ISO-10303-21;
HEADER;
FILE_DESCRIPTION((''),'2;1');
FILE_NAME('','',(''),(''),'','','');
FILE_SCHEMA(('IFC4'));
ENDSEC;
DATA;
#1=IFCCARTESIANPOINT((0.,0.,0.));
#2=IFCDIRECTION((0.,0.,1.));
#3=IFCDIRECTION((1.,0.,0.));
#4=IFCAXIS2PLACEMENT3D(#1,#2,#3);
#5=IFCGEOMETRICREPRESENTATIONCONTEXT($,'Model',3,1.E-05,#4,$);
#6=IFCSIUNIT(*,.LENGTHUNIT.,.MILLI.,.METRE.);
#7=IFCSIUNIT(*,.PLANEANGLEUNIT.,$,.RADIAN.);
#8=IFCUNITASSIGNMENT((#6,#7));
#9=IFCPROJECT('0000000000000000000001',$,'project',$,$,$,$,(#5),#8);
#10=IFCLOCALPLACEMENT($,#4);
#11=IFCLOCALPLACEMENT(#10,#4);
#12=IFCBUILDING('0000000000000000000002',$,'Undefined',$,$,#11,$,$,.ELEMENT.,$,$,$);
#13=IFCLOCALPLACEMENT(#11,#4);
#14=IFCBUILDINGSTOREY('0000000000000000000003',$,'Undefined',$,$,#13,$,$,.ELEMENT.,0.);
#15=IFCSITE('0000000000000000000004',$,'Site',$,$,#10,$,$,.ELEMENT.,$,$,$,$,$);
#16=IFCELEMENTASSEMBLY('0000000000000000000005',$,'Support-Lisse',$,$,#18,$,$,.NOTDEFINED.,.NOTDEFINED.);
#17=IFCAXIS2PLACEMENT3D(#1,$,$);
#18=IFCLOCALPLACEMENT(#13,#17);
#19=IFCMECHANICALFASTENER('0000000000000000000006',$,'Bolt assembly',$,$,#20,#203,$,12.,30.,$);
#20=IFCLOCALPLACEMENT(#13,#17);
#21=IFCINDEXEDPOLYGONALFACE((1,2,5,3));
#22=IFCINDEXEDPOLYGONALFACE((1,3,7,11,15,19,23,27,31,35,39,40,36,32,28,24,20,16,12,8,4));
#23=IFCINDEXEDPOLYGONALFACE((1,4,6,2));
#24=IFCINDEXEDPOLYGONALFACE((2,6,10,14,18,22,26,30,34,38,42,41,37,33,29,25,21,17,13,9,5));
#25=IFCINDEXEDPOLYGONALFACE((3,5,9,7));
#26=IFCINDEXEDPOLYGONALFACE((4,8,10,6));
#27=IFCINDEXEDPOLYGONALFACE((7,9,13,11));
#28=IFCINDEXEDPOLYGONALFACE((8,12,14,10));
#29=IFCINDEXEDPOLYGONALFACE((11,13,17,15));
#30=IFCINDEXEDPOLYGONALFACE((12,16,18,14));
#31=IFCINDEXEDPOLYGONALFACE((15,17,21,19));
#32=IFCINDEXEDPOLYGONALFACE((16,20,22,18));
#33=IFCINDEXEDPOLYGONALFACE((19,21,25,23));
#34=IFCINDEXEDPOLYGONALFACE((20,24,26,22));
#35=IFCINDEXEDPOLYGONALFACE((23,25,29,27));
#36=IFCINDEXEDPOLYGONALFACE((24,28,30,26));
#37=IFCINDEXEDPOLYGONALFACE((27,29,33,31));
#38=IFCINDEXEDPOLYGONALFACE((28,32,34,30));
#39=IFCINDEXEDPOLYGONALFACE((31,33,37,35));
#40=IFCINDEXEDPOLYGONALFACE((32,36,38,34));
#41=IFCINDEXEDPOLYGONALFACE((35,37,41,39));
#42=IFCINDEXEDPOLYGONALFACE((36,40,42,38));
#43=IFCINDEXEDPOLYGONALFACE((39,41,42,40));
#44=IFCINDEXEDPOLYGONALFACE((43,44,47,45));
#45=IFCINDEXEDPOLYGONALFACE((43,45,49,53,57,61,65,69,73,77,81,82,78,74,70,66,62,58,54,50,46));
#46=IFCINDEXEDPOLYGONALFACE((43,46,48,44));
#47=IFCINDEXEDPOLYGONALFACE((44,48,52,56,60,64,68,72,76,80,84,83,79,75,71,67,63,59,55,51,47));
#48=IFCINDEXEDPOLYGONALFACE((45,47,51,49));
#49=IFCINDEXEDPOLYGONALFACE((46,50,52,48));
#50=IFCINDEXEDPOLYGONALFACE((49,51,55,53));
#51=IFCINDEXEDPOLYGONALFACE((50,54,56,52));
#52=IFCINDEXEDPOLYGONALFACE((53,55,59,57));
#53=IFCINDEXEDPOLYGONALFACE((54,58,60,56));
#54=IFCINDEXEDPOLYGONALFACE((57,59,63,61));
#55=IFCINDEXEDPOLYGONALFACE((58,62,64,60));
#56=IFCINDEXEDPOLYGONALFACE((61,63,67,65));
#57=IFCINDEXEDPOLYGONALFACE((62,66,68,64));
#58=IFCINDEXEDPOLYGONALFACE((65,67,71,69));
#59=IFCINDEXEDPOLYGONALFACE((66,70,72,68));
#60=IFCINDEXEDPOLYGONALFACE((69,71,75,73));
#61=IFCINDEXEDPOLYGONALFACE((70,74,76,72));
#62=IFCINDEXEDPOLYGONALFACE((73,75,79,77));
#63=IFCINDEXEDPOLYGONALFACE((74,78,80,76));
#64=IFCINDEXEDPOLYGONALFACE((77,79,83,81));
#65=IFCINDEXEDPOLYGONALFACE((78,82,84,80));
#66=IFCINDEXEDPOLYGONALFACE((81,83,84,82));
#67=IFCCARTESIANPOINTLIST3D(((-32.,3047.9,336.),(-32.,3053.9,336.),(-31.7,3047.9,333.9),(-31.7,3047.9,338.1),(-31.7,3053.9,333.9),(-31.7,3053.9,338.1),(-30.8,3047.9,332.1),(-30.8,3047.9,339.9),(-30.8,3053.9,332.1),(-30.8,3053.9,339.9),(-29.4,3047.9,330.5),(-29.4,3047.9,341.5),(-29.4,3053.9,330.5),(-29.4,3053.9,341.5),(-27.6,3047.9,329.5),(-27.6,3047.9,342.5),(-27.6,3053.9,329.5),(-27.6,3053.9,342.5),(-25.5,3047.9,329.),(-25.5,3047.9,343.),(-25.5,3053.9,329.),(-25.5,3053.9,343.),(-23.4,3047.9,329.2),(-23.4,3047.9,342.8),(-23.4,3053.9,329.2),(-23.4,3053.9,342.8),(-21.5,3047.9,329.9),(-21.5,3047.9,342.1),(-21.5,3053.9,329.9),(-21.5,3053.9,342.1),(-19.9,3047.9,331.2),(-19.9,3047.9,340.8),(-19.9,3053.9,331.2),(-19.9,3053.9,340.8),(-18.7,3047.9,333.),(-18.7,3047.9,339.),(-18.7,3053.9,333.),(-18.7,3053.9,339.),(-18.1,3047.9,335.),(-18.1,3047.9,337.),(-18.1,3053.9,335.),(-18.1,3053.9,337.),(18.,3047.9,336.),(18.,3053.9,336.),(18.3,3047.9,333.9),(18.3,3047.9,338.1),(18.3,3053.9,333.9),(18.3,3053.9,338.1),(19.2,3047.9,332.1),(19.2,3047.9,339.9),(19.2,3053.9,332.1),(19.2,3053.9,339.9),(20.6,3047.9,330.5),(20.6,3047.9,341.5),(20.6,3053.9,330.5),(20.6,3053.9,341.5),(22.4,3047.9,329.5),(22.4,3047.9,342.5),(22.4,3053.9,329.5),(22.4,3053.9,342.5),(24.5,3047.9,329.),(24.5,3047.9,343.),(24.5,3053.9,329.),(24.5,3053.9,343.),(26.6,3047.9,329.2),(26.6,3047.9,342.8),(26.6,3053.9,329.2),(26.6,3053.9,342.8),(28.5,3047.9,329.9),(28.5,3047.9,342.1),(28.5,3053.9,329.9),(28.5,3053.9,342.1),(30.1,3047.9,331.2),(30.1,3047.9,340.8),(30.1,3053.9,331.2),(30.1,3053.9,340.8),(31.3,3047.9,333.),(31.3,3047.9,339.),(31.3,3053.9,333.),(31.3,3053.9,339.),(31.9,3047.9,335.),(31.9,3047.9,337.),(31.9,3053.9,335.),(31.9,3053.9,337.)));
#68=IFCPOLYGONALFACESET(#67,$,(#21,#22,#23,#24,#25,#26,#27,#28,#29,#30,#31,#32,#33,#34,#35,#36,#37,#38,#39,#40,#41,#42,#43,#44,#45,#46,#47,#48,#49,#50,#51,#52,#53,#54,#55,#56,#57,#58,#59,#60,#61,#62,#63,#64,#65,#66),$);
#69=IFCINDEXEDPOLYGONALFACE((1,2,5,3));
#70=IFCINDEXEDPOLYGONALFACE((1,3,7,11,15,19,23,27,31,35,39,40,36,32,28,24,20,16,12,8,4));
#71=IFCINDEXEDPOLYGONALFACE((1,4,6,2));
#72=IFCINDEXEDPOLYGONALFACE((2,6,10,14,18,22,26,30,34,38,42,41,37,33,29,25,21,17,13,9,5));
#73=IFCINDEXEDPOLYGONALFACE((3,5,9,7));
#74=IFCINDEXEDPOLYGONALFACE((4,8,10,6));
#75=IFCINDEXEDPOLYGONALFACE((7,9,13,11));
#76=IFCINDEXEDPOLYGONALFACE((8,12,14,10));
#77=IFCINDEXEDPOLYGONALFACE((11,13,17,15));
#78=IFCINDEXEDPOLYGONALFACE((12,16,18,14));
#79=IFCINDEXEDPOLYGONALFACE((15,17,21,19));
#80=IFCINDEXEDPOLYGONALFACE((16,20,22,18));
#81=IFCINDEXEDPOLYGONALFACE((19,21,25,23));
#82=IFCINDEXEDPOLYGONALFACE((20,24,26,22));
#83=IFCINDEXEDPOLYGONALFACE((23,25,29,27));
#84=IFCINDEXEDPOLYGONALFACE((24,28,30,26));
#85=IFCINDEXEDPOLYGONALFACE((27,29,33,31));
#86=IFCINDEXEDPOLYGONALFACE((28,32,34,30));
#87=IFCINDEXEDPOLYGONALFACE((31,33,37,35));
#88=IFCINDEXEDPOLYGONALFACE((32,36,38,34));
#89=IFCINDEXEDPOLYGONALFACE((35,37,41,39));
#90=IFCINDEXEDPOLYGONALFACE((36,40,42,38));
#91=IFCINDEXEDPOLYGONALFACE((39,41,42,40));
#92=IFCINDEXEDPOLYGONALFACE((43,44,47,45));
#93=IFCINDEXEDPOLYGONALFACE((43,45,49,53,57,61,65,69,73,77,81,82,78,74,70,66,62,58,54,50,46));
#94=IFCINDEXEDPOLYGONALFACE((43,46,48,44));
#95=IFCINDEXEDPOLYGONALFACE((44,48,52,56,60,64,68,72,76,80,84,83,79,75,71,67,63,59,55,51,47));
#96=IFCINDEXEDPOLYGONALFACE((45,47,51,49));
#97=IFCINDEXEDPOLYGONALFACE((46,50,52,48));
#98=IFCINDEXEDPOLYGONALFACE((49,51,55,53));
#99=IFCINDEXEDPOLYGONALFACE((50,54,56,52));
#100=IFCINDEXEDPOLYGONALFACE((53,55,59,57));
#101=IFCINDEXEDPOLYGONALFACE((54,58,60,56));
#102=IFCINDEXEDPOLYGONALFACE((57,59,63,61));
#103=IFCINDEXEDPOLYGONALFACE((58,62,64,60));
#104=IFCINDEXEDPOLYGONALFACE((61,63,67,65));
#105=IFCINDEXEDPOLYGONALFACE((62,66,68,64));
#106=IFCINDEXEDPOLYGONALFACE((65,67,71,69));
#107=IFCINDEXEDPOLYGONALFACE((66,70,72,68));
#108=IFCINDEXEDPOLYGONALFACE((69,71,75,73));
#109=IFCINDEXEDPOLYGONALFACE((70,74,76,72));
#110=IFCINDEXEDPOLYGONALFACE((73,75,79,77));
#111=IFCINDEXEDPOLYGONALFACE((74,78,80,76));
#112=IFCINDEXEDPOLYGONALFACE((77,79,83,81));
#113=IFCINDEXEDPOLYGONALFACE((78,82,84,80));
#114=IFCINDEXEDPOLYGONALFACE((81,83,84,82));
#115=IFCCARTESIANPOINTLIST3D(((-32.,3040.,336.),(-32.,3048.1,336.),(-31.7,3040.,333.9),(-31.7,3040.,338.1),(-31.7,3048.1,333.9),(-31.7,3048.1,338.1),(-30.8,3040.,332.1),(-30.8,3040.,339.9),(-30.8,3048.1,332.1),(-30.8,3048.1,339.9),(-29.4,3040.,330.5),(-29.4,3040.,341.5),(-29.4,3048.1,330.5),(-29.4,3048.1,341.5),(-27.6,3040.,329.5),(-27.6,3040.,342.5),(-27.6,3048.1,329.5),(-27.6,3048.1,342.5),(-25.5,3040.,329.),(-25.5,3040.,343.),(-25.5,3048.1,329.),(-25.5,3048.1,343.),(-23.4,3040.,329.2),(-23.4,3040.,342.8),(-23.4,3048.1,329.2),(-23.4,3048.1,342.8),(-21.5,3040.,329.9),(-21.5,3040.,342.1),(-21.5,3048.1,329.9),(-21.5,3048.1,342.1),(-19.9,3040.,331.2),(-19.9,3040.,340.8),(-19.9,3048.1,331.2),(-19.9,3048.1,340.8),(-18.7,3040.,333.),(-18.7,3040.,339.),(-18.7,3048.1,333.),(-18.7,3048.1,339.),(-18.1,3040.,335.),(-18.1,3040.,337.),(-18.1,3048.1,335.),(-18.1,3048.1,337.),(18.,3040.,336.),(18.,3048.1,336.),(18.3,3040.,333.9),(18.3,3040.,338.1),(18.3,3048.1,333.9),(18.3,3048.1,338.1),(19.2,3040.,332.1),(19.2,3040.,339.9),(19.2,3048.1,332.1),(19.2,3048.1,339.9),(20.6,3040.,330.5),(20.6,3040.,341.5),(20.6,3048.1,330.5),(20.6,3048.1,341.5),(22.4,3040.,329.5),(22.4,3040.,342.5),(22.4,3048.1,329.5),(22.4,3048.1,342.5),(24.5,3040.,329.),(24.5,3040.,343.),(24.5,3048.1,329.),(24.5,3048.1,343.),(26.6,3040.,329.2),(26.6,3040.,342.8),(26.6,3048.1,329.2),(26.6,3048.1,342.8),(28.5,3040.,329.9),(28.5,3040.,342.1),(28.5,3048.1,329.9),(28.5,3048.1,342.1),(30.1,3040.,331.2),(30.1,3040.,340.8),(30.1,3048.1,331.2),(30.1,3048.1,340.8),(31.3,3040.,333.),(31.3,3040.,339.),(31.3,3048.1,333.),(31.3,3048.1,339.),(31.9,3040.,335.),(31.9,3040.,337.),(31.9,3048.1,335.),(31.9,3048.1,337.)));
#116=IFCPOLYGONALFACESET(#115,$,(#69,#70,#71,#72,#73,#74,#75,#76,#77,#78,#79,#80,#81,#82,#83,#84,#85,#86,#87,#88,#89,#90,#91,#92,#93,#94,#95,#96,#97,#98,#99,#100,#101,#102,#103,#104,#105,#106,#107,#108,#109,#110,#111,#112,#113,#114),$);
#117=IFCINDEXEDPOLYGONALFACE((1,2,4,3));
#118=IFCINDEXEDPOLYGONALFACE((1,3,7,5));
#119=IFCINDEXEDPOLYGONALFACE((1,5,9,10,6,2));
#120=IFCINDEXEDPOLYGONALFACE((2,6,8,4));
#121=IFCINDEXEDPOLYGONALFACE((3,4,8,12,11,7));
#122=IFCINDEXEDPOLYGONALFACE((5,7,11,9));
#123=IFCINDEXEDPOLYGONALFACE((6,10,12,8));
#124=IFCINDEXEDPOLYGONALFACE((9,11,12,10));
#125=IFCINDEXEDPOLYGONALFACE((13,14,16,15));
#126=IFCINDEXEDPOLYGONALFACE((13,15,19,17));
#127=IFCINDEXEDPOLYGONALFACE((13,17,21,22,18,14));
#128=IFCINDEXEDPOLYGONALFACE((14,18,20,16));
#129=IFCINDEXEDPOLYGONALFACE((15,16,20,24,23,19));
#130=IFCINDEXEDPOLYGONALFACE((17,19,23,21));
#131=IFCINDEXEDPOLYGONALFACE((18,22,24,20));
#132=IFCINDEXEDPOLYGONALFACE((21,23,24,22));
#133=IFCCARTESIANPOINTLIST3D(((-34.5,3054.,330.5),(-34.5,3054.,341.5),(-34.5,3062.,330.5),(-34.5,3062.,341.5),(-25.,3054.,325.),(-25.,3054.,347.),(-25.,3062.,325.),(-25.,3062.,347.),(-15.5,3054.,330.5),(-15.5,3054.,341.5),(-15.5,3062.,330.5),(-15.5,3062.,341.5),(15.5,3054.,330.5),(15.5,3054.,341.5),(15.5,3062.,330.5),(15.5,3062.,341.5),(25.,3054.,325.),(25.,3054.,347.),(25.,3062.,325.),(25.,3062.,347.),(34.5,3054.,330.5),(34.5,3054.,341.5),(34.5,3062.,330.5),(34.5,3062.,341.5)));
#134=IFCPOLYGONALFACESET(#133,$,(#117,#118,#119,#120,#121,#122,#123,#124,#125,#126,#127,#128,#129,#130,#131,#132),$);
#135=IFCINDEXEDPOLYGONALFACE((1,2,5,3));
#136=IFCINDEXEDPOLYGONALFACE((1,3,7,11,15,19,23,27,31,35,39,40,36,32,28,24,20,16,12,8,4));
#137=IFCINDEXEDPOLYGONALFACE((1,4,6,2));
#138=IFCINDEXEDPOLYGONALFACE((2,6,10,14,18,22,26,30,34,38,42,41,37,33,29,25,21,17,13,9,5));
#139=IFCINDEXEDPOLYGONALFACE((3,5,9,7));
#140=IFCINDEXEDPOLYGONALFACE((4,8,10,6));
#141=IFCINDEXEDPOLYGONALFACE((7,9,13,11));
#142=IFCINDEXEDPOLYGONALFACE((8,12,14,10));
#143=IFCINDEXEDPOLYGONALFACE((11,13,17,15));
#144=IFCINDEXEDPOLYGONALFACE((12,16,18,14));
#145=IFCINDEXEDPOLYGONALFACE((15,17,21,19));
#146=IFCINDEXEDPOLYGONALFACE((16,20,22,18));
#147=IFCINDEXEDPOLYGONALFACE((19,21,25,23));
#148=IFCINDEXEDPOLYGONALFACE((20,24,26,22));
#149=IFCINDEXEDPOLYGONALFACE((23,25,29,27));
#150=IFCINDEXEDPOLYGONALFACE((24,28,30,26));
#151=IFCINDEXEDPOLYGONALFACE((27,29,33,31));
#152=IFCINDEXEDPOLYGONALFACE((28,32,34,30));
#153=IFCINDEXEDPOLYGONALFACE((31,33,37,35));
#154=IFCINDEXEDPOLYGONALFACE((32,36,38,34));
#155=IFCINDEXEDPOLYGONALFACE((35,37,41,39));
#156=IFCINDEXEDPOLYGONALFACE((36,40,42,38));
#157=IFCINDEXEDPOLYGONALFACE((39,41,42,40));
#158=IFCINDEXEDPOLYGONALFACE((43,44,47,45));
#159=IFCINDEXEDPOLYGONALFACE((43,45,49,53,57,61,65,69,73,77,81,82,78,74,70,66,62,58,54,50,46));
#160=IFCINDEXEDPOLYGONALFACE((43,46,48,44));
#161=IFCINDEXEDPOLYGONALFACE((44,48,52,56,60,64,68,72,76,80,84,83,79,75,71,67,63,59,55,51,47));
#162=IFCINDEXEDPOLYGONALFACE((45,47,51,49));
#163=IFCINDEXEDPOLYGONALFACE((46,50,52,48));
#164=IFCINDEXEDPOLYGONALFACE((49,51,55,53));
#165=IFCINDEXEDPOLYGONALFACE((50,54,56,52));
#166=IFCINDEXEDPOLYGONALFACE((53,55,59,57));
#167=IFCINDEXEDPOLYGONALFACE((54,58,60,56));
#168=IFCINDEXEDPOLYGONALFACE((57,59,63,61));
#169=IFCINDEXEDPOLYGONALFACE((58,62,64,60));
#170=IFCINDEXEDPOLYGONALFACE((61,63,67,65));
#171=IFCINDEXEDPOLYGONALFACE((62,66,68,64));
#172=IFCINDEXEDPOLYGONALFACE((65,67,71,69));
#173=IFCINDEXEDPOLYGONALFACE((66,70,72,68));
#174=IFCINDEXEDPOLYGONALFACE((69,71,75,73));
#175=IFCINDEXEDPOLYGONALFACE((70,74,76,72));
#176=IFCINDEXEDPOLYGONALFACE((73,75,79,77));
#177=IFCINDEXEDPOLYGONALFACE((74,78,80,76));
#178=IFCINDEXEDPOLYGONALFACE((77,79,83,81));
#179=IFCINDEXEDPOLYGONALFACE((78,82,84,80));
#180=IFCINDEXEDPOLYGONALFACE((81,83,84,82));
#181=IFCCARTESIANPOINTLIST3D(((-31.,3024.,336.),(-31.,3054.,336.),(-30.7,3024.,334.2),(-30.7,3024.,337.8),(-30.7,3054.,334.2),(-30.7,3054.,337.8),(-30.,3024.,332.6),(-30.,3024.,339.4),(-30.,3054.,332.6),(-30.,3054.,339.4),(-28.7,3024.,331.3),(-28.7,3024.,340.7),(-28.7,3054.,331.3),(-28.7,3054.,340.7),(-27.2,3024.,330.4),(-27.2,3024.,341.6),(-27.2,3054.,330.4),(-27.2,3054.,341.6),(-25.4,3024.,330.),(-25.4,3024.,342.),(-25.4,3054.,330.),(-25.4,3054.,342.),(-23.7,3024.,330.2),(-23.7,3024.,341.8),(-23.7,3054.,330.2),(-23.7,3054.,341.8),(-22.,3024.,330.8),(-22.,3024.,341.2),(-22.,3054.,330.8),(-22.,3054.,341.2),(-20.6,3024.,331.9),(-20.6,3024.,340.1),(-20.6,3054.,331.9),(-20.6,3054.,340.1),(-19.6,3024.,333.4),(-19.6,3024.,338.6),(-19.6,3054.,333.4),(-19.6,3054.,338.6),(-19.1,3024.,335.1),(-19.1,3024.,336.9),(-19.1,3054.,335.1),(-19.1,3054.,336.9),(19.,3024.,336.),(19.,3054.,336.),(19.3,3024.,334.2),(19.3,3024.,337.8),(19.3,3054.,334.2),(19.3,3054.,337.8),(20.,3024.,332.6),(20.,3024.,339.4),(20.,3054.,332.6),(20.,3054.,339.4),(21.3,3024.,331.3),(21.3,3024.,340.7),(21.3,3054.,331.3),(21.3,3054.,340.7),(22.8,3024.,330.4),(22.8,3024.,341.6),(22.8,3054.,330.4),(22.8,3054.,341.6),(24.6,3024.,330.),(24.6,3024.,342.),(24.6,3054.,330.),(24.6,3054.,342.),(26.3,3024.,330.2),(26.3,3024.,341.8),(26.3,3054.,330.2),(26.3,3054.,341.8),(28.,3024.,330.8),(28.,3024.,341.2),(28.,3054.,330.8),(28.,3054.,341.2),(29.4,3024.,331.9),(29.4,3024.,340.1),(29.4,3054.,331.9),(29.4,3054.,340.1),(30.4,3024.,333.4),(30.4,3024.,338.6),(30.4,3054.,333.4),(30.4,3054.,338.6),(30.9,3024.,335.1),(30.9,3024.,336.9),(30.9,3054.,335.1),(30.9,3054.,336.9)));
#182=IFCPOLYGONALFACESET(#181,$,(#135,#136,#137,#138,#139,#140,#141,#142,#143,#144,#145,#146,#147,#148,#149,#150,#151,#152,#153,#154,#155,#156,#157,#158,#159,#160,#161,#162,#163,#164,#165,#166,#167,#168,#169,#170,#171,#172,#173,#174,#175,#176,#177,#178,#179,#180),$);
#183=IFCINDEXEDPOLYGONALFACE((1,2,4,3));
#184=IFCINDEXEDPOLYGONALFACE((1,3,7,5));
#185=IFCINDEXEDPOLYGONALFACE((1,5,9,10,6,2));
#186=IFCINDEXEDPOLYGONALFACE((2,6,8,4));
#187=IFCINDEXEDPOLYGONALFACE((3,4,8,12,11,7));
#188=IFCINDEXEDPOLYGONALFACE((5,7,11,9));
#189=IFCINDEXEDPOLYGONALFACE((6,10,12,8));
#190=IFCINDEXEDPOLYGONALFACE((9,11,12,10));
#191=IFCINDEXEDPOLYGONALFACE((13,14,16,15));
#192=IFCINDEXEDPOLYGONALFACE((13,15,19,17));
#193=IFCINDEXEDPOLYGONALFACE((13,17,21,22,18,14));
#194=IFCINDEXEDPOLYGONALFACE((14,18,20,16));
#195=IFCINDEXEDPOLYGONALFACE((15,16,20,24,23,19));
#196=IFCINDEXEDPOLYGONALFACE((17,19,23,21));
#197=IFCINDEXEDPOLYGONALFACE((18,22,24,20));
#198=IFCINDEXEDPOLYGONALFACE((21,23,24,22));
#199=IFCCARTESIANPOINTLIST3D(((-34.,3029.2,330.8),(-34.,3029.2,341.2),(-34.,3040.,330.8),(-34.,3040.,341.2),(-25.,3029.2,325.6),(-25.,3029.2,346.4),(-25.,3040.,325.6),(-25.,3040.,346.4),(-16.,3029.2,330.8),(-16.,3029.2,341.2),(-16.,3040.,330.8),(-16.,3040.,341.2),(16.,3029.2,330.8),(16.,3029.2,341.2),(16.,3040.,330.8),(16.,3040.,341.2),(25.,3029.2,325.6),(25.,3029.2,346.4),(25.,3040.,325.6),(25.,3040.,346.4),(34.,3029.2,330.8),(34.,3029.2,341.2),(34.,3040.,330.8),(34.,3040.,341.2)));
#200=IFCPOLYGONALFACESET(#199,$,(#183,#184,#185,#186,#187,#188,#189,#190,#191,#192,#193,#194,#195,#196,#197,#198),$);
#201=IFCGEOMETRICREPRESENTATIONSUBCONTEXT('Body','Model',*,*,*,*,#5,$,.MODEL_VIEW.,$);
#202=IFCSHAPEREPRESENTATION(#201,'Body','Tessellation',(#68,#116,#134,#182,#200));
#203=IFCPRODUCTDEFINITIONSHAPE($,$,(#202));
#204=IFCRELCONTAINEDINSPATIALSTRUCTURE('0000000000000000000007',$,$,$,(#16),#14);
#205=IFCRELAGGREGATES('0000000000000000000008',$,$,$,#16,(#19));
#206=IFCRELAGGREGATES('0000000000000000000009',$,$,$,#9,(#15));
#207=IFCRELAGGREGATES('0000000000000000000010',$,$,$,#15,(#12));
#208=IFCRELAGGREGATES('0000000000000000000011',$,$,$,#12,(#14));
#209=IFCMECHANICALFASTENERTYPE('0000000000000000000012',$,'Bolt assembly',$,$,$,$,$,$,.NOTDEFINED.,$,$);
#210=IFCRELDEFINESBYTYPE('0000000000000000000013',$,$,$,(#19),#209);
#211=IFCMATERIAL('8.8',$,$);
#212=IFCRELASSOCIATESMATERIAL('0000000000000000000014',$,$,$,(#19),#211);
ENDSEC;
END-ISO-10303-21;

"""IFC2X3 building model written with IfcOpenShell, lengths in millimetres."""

from ifc_helpers import new_model, si_unit, frame, origin_with_axes, origin_2d_with_axis, place, context, subcontext, project, spatial, polyline, circle, outline, extrude, source, transform, mapped, material, type_object, element, aggregate, save


model = new_model("IFC2X3")

# Units and contexts
model_context = context("Model", 3, precision=1e-05, world=origin_with_axes())
body_context = subcontext(model_context, "Body", "Model", "MODEL_VIEW")
ifc_project = project(units=[si_unit("LENGTHUNIT", "METRE", prefix="MILLI"), si_unit("PLANEANGLEUNIT", "RADIAN")], contexts=[model_context])

# Site, building, storey
site_placement = place(None, origin_with_axes())
site = spatial("IfcSite", under=ifc_project, at=site_placement, Name="Site", CompositionType="ELEMENT")
building_placement = place(site_placement, origin_with_axes())
building = spatial("IfcBuilding", under=site, at=building_placement, Name="Undefined", CompositionType="ELEMENT")
storey_placement = place(building_placement, origin_with_axes())
storey = spatial("IfcBuildingStorey", under=building, at=storey_placement, Name="Undefined", CompositionType="ELEMENT", Elevation=0.0)

# Shared definitions
mechanical_fastener_type = type_object("IfcMechanicalFastenerType", Name="Bolt assembly")
ifc_material_1 = material(Name="8.8")

# Shared definitions
shared_shape_1 = source(origin_with_axes(), body_context, "Body", "SweptSolid", [
    extrude(circle(Radius=7.0, at=origin_2d_with_axis()), frame((0.0, -5.9, 0.0), z_axis=(0.0, 1.0, 0.0), x_axis=(1.0, 0.0, 0.0)), (0.0, 0.0, 1.0), 6.0),
    extrude(circle(Radius=7.0, at=origin_2d_with_axis()), frame((0.0, -0.1, 0.0), z_axis=(0.0, 1.0, 0.0), x_axis=(1.0, 0.0, 0.0)), (0.0, 0.0, 1.0), 8.1),
    extrude(outline(polyline([(9.5, -5.5), (9.5, 5.5), (0.0, 11.0), (-9.5, 5.5), (-9.5, -5.5), (0.0, -11.0), (9.5, -5.5)])), frame((0.0, -14.0, 0.0), z_axis=(0.0, 1.0, 0.0), x_axis=(1.0, 0.0, 0.0)), (0.0, 0.0, 1.0), 8.0),
    extrude(circle(Radius=6.0, at=origin_2d_with_axis()), frame((0.0, -6.0, 0.0), z_axis=(0.0, 1.0, 0.0), x_axis=(1.0, 0.0, 0.0)), (0.0, 0.0, 1.0), 30.0),
    extrude(outline(polyline([(9.0, -5.2), (9.0, 5.2), (0.0, 10.4), (-9.0, 5.2), (-9.0, -5.2), (0.0, -10.4), (9.0, -5.2)])), frame((0.0, 8.0, 0.0), z_axis=(0.0, 1.0, 0.0), x_axis=(1.0, 0.0, 0.0)), (0.0, 0.0, 1.0), 10.8),
])

# Element assembly, mechanical fastener
assembly_1_placement = place(storey_placement, origin_with_axes())
assembly_1 = element("IfcElementAssembly", 1, at=assembly_1_placement, inside=storey, Name="Support-Lisse", AssemblyPlace="NOTDEFINED", PredefinedType="NOTDEFINED")
mechanical_fastener_1_placement = place(assembly_1_placement, frame((25.0, 3048.0, 336.0), z_axis=(0.0, 0.0, 1.0), x_axis=(-1.0, 0.0, 0.0)))
mechanical_fastener_1 = element("IfcMechanicalFastener", 2, at=mechanical_fastener_1_placement, type_object=mechanical_fastener_type, material=ifc_material_1, Name="Bolt assembly", NominalDiameter=12.0, NominalLength=30.0, context=body_context, shape_type="MappedRepresentation", body=[
    mapped(shared_shape_1, transform((0.0, 0.0, 0.0))),
    mapped(shared_shape_1, transform((50.0, 0.0, 0.0))),
])
aggregate(assembly_1, [mechanical_fastener_1])

save(model, "model.ifc")
